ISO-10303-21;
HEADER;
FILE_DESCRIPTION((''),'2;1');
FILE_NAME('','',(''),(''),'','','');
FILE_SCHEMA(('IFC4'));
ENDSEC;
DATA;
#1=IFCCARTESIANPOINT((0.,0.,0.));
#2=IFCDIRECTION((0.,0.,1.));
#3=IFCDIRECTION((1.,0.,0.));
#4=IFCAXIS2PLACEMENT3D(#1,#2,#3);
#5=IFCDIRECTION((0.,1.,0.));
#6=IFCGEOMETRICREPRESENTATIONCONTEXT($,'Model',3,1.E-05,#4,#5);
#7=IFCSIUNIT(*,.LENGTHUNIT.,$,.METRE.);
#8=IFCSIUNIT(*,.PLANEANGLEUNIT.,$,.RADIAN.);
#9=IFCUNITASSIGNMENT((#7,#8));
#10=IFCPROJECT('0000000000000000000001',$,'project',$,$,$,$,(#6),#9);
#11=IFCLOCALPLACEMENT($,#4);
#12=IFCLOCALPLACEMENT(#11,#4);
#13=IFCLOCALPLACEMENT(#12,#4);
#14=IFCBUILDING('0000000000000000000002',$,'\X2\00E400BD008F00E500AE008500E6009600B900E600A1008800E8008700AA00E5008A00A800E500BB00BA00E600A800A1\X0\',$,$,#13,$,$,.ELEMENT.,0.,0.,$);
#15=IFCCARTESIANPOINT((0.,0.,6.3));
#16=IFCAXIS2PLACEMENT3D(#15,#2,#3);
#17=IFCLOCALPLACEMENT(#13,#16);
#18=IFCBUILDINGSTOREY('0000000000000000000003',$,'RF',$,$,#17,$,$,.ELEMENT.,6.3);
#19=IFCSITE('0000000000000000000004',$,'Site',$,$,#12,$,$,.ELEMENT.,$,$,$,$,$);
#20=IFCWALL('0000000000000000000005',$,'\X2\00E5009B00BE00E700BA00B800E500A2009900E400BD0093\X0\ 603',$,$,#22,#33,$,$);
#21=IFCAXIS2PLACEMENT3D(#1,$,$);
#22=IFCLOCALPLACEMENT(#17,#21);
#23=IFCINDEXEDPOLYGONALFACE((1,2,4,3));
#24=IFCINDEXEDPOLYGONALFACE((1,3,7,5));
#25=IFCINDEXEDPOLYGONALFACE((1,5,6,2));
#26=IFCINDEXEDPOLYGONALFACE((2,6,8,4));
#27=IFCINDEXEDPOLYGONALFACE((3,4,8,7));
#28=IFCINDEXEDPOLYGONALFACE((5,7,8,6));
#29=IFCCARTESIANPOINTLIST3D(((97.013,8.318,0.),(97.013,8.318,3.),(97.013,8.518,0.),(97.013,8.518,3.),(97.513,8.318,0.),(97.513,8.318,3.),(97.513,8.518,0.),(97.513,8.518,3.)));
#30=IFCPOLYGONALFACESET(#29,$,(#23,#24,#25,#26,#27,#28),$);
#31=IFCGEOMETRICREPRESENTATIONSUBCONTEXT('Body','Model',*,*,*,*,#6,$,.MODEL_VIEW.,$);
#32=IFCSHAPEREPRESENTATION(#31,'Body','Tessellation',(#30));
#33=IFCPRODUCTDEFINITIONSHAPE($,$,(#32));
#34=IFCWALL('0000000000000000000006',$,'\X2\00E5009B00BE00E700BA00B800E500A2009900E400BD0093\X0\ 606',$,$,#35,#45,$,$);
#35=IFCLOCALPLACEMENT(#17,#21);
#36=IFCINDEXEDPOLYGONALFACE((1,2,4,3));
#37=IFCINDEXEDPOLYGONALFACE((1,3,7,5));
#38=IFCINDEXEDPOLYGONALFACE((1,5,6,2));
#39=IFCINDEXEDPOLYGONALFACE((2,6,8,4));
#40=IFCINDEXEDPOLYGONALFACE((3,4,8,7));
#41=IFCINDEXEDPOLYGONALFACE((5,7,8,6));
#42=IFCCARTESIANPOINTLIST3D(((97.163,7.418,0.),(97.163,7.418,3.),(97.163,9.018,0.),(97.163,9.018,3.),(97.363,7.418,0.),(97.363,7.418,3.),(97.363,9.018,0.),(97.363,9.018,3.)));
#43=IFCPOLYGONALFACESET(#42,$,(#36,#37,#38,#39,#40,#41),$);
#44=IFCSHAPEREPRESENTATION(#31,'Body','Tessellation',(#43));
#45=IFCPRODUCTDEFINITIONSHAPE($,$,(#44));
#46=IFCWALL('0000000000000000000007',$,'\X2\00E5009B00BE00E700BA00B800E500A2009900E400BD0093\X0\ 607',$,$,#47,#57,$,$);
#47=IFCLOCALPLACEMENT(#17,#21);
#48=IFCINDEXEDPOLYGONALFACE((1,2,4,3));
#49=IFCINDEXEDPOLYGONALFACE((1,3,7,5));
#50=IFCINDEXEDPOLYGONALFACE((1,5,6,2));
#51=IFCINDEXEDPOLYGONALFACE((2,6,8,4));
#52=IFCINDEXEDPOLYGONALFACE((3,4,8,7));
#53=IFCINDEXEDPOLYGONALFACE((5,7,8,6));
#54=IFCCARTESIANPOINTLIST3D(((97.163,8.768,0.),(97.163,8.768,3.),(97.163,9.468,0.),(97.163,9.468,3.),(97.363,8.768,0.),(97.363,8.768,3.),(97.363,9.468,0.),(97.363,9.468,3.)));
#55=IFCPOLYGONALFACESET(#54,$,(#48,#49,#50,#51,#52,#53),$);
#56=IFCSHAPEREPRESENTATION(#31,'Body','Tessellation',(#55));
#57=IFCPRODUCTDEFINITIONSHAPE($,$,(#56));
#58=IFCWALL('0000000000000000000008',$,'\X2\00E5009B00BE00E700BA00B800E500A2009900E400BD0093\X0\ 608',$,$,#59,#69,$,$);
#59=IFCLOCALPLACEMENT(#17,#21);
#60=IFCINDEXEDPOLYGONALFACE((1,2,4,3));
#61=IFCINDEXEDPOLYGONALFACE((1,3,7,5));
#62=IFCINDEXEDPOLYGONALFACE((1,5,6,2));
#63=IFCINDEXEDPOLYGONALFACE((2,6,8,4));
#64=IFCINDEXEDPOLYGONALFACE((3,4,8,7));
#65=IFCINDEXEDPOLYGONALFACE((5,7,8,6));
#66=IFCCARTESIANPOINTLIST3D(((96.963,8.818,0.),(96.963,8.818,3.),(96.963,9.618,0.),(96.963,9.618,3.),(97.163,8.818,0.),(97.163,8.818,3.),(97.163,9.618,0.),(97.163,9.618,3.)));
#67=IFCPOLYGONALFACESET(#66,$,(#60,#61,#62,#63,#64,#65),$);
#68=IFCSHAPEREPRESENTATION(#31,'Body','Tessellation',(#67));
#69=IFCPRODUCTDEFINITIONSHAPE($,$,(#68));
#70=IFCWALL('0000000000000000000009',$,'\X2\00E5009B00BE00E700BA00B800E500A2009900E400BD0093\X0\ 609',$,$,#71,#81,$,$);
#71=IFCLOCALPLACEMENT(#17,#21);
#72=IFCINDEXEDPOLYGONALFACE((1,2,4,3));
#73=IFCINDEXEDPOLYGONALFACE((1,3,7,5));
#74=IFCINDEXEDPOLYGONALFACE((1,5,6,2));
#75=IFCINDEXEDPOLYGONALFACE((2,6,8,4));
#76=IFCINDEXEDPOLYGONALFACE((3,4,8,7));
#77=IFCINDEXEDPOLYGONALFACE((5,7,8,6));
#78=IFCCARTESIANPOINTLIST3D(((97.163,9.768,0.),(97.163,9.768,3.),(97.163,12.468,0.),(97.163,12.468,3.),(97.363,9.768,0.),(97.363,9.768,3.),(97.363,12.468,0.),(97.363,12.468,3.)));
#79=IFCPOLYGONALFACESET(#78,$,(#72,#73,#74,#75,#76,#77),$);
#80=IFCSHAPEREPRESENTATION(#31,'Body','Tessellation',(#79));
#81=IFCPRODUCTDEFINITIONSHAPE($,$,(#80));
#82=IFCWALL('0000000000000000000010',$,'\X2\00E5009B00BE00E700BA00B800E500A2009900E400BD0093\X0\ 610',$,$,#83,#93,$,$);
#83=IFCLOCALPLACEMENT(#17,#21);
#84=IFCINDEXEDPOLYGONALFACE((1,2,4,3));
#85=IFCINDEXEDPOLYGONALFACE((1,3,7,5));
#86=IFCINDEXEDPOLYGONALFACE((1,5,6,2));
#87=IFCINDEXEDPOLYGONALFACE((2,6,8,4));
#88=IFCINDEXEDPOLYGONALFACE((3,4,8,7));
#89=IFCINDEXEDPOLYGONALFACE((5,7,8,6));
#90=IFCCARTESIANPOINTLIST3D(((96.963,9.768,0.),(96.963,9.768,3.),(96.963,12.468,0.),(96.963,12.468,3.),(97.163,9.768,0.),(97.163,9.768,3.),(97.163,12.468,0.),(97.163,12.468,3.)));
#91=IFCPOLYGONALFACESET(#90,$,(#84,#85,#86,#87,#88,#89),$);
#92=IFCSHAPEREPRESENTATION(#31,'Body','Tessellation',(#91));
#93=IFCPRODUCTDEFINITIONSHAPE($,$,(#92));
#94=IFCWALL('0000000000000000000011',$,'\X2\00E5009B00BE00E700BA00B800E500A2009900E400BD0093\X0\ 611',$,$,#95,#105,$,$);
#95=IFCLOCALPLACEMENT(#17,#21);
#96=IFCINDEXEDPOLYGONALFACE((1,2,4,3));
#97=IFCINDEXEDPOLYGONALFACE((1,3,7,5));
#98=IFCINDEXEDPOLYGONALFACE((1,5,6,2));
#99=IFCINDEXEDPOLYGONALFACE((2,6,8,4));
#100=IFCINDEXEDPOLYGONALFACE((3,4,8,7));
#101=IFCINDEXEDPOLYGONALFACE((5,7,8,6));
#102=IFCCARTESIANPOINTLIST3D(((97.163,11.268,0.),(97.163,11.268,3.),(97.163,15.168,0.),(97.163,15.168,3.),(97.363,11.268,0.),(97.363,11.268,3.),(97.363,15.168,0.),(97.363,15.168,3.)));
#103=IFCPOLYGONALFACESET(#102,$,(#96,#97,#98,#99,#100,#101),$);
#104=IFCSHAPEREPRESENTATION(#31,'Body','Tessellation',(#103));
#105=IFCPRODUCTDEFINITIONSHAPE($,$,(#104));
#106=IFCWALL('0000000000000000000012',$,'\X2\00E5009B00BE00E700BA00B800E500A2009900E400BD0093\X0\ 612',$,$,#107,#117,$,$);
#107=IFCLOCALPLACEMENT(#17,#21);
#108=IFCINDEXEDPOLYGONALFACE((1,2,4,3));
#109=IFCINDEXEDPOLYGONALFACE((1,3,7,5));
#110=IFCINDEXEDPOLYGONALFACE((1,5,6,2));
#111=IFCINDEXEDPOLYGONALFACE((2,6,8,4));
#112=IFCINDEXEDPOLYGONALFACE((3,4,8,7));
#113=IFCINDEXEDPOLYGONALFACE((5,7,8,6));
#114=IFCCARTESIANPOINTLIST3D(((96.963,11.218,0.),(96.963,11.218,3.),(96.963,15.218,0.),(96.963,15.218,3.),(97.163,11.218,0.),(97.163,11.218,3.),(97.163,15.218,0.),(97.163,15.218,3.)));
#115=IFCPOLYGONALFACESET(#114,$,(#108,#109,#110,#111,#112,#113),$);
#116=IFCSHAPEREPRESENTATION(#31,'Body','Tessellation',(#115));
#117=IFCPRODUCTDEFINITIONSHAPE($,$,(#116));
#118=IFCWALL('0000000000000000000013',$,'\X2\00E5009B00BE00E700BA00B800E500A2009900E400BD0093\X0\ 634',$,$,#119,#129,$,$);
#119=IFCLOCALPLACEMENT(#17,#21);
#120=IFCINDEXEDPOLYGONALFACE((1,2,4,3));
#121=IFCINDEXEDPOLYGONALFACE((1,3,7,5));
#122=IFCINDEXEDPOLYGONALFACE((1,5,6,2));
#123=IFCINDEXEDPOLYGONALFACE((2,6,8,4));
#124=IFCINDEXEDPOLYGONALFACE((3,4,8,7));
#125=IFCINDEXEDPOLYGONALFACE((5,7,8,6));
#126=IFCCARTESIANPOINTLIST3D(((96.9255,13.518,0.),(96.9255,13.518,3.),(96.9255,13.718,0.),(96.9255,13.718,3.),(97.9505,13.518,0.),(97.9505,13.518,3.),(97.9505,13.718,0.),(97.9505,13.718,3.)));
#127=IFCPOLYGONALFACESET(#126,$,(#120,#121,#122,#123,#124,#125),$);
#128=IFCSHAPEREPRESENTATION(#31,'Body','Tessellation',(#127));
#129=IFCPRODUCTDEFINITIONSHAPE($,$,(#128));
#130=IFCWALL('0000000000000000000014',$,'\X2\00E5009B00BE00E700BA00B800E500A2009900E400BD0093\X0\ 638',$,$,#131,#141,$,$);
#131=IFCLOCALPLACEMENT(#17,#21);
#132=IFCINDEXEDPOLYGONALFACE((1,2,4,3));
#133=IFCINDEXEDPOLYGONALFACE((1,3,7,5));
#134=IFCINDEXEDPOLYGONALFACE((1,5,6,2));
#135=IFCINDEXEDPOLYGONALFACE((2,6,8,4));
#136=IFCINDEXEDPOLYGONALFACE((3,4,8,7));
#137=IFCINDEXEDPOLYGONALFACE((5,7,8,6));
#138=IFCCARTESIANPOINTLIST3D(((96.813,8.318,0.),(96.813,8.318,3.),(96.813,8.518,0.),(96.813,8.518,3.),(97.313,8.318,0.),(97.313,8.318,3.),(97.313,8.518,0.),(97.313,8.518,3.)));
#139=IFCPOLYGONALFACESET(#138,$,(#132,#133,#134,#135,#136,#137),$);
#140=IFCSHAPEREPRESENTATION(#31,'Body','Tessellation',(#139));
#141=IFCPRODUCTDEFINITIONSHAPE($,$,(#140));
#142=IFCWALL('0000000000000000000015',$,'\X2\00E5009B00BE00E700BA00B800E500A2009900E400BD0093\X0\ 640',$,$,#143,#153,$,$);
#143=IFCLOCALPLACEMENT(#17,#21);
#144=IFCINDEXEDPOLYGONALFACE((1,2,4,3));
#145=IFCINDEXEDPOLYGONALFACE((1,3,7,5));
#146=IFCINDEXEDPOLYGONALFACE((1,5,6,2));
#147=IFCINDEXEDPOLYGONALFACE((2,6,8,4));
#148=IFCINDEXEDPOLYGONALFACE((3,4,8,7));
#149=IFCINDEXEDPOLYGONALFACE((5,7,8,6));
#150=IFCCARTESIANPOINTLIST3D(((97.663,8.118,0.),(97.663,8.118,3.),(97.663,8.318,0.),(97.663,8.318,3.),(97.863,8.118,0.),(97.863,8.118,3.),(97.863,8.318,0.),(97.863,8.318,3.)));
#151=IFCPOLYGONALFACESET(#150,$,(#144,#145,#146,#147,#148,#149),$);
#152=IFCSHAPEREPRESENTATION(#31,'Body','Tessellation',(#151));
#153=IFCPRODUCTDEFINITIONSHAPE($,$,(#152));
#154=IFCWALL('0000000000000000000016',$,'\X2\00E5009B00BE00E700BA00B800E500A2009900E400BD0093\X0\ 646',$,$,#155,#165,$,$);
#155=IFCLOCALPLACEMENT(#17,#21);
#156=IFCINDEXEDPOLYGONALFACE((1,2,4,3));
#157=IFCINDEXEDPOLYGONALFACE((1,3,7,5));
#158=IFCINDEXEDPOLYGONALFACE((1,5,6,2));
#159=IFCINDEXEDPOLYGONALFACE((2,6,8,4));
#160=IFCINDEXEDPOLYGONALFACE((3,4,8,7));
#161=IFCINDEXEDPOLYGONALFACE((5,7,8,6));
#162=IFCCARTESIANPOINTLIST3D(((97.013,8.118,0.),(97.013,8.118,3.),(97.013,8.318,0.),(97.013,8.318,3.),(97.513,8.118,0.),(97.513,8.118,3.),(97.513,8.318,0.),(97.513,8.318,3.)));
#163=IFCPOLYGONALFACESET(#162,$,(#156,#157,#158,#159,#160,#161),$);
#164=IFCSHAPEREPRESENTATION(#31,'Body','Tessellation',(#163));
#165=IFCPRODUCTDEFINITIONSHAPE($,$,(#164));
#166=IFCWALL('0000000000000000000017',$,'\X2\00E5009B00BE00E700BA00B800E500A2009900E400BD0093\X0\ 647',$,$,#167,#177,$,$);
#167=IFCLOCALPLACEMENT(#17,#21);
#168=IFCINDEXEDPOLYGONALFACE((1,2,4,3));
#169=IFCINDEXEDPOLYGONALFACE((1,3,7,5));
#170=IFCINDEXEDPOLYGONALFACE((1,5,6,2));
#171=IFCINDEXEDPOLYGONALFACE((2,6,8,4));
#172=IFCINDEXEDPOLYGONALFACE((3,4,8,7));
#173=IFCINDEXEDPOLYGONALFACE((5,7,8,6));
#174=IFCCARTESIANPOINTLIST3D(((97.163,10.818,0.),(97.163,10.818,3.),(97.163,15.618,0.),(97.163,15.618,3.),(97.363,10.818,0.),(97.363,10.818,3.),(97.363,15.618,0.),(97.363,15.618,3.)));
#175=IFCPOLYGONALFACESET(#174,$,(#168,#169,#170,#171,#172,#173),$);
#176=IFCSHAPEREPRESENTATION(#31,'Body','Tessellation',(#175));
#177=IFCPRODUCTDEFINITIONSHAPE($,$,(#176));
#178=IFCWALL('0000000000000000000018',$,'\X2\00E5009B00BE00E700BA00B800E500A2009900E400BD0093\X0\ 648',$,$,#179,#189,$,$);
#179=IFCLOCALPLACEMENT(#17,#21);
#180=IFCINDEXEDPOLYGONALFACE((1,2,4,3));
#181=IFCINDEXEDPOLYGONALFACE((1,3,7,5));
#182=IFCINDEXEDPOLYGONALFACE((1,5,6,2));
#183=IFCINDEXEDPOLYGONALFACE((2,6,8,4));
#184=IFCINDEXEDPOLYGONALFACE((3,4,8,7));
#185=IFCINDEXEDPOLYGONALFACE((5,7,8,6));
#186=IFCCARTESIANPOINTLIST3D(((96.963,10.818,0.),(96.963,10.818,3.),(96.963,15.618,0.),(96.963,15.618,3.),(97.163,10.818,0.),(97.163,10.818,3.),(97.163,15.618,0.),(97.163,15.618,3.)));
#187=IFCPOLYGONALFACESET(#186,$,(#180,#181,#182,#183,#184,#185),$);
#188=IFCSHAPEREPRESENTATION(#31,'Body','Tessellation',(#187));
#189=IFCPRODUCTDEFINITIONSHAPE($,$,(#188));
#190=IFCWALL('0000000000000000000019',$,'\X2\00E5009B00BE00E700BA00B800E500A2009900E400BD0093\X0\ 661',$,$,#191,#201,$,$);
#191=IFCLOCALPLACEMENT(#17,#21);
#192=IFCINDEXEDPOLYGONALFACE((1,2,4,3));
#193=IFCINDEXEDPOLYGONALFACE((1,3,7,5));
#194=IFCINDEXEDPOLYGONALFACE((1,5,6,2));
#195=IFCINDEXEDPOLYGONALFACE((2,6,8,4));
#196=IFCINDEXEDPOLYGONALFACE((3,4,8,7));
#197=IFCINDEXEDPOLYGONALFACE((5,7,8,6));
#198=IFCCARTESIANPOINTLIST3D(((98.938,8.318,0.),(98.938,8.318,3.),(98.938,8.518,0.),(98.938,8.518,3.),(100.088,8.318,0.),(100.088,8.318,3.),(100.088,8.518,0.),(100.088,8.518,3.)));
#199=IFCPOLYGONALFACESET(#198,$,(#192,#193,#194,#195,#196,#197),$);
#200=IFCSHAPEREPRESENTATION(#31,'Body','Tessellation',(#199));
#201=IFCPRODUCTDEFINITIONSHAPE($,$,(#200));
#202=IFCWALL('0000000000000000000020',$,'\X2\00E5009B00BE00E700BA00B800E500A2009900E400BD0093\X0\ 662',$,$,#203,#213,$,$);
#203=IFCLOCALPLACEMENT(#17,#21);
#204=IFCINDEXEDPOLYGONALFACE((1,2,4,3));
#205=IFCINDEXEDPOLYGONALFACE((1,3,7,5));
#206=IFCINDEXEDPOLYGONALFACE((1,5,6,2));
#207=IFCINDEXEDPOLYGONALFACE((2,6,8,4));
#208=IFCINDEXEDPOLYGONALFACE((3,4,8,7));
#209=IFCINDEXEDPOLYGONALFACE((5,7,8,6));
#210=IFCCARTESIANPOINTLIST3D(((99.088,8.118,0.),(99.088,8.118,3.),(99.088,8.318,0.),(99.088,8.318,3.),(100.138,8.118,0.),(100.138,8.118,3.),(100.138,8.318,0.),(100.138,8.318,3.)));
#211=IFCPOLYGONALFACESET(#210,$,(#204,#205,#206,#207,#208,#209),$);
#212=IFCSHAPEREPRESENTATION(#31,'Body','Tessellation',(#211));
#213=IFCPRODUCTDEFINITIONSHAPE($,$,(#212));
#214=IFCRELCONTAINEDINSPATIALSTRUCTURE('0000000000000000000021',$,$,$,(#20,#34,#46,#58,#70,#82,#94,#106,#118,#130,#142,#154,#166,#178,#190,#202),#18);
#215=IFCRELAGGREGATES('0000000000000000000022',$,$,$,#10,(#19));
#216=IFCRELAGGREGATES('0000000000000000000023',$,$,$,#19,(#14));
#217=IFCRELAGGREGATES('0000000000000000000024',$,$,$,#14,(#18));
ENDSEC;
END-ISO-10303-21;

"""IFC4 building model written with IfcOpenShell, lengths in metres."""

from ifc_helpers import new_model, si_unit, direction, frame, frame_2d, origin_with_axes, place, context, subcontext, project, spatial, rectangle, extrude, element, save


model = new_model("IFC4")

# Units and contexts
model_context = context("Model", 3, precision=1e-05, world=origin_with_axes(), true_north=direction((0.0, 1.0, 0.0)))
body_context = subcontext(model_context, "Body", "Model", "MODEL_VIEW")
ifc_project = project(units=[si_unit("LENGTHUNIT", "METRE"), si_unit("PLANEANGLEUNIT", "RADIAN")], contexts=[model_context])

# Site, building, storey
placement = place(None, origin_with_axes())
site_placement = place(placement, origin_with_axes())
site = spatial("IfcSite", under=ifc_project, at=site_placement, Name="Site", CompositionType="ELEMENT")
building_placement = place(site_placement, origin_with_axes())
building = spatial("IfcBuilding", under=site, at=building_placement, Name="ä½\u008få®\u0085æ\u0096¹æ¡\u0088è\u0087ªå\u008a¨å»ºæ¨¡", CompositionType="ELEMENT", ElevationOfRefHeight=0.0, ElevationOfTerrain=0.0)
storey_placement = place(building_placement, frame((0.0, 0.0, 6.3), z_axis=(0.0, 0.0, 1.0), x_axis=(1.0, 0.0, 0.0)))
storey = spatial("IfcBuildingStorey", under=building, at=storey_placement, Name="RF", CompositionType="ELEMENT", Elevation=6.3)

# Walls
wall_1_placement = place(storey_placement, frame((97.263, 8.418, 0.0), z_axis=(0.0, 0.0, 1.0), x_axis=(1.0, 0.0, 0.0)))
element("IfcWall", 1, at=wall_1_placement, inside=storey, Name="å\u009b¾çº¸å¢\u0099ä½\u0093 603", context=body_context, shape_type="SweptSolid", body=[
    extrude(rectangle(XDim=0.5, YDim=0.2, at=frame_2d((0.0, 0.0), x_axis=(1.0, 0.0, 0.0))), frame((0.0, 0.0, 0.0), z_axis=(0.0, 0.0, 1.0)), (0.0, 0.0, 1.0), 3.0),
])
wall_2_placement = place(storey_placement, frame((97.263, 8.218, 0.0), z_axis=(0.0, 0.0, 1.0), x_axis=(0.0, -1.0, 0.0)))
element("IfcWall", 2, at=wall_2_placement, inside=storey, Name="å\u009b¾çº¸å¢\u0099ä½\u0093 606", context=body_context, shape_type="SweptSolid", body=[
    extrude(rectangle(XDim=1.6, YDim=0.2, at=frame_2d((0.0, 0.0), x_axis=(1.0, 0.0, 0.0))), frame((0.0, 0.0, 0.0), z_axis=(0.0, 0.0, 1.0)), (0.0, 0.0, 1.0), 3.0),
])
wall_3_placement = place(storey_placement, frame((97.263, 9.118, 0.0), z_axis=(0.0, 0.0, 1.0), x_axis=(0.0, -1.0, 0.0)))
element("IfcWall", 3, at=wall_3_placement, inside=storey, Name="å\u009b¾çº¸å¢\u0099ä½\u0093 607", context=body_context, shape_type="SweptSolid", body=[
    extrude(rectangle(XDim=0.7, YDim=0.2, at=frame_2d((0.0, 0.0), x_axis=(1.0, 0.0, 0.0))), frame((0.0, 0.0, 0.0), z_axis=(0.0, 0.0, 1.0)), (0.0, 0.0, 1.0), 3.0),
])
wall_4_placement = place(storey_placement, frame((97.063, 9.218, 0.0), z_axis=(0.0, 0.0, 1.0), x_axis=(0.0, -1.0, 0.0)))
element("IfcWall", 4, at=wall_4_placement, inside=storey, Name="å\u009b¾çº¸å¢\u0099ä½\u0093 608", context=body_context, shape_type="SweptSolid", body=[
    extrude(rectangle(XDim=0.8, YDim=0.2, at=frame_2d((0.0, 0.0), x_axis=(1.0, 0.0, 0.0))), frame((0.0, 0.0, 0.0), z_axis=(0.0, 0.0, 1.0)), (0.0, 0.0, 1.0), 3.0),
])
for number, where, z_axis, x_axis, name in (
    (5, (97.263, 11.118, 0.0), (0.0, 0.0, 1.0), (0.0, -1.0, 0.0), "å\u009b¾çº¸å¢\u0099ä½\u0093 609"),
    (6, (97.063, 11.118, 0.0), (0.0, 0.0, 1.0), (0.0, -1.0, 0.0), "å\u009b¾çº¸å¢\u0099ä½\u0093 610"),
):
    element("IfcWall", number, at=place(storey_placement, frame(where, z_axis=z_axis, x_axis=x_axis)), inside=storey, Name=name, context=body_context, shape_type="SweptSolid", body=[
        extrude(rectangle(XDim=2.7, YDim=0.2, at=frame_2d((0.0, 0.0), x_axis=(1.0, 0.0, 0.0))), frame((0.0, 0.0, 0.0), z_axis=(0.0, 0.0, 1.0)), (0.0, 0.0, 1.0), 3.0),
    ])
wall_5_placement = place(storey_placement, frame((97.263, 13.218, 0.0), z_axis=(0.0, 0.0, 1.0), x_axis=(0.0, -1.0, 0.0)))
element("IfcWall", 7, at=wall_5_placement, inside=storey, Name="å\u009b¾çº¸å¢\u0099ä½\u0093 611", context=body_context, shape_type="SweptSolid", body=[
    extrude(rectangle(XDim=3.9, YDim=0.2, at=frame_2d((0.0, 0.0), x_axis=(1.0, 0.0, 0.0))), frame((0.0, 0.0, 0.0), z_axis=(0.0, 0.0, 1.0)), (0.0, 0.0, 1.0), 3.0),
])
wall_6_placement = place(storey_placement, frame((97.063, 13.218, 0.0), z_axis=(0.0, 0.0, 1.0), x_axis=(0.0, -1.0, 0.0)))
element("IfcWall", 8, at=wall_6_placement, inside=storey, Name="å\u009b¾çº¸å¢\u0099ä½\u0093 612", context=body_context, shape_type="SweptSolid", body=[
    extrude(rectangle(XDim=4.0, YDim=0.2, at=frame_2d((0.0, 0.0), x_axis=(1.0, 0.0, 0.0))), frame((0.0, 0.0, 0.0), z_axis=(0.0, 0.0, 1.0)), (0.0, 0.0, 1.0), 3.0),
])
wall_7_placement = place(storey_placement, frame((97.438, 13.618, 0.0), z_axis=(0.0, 0.0, 1.0), x_axis=(1.0, 0.0, 0.0)))
element("IfcWall", 9, at=wall_7_placement, inside=storey, Name="å\u009b¾çº¸å¢\u0099ä½\u0093 634", context=body_context, shape_type="SweptSolid", body=[
    extrude(rectangle(XDim=1.025, YDim=0.2, at=frame_2d((0.0, 0.0), x_axis=(1.0, 0.0, 0.0))), frame((0.0, 0.0, 0.0), z_axis=(0.0, 0.0, 1.0)), (0.0, 0.0, 1.0), 3.0),
])
wall_8_placement = place(storey_placement, frame((97.063, 8.418, 0.0), z_axis=(0.0, 0.0, 1.0), x_axis=(-1.0, 0.0, 0.0)))
element("IfcWall", 10, at=wall_8_placement, inside=storey, Name="å\u009b¾çº¸å¢\u0099ä½\u0093 638", context=body_context, shape_type="SweptSolid", body=[
    extrude(rectangle(XDim=0.5, YDim=0.2, at=frame_2d((0.0, 0.0), x_axis=(1.0, 0.0, 0.0))), frame((0.0, 0.0, 0.0), z_axis=(0.0, 0.0, 1.0)), (0.0, 0.0, 1.0), 3.0),
])
wall_9_placement = place(storey_placement, frame((97.763, 8.218, 0.0), z_axis=(0.0, 0.0, 1.0), x_axis=(0.0, 1.0, 0.0)))
element("IfcWall", 11, at=wall_9_placement, inside=storey, Name="å\u009b¾çº¸å¢\u0099ä½\u0093 640", context=body_context, shape_type="SweptSolid", body=[
    extrude(rectangle(XDim=0.2, YDim=0.2, at=frame_2d((0.0, 0.0), x_axis=(1.0, 0.0, 0.0))), frame((0.0, 0.0, 0.0), z_axis=(0.0, 0.0, 1.0)), (0.0, 0.0, 1.0), 3.0),
])
for number, where, z_axis, x_axis, name in (
    (12, (97.263, 8.218, 0.0), (0.0, 0.0, 1.0), (1.0, 0.0, 0.0), "å\u009b¾çº¸å¢\u0099ä½\u0093 646"),
):
    element("IfcWall", number, at=place(storey_placement, frame(where, z_axis=z_axis, x_axis=x_axis)), inside=storey, Name=name, context=body_context, shape_type="SweptSolid", body=[
        extrude(rectangle(XDim=0.5, YDim=0.2, at=frame_2d((0.0, 0.0), x_axis=(1.0, 0.0, 0.0))), frame((0.0, 0.0, 0.0), z_axis=(0.0, 0.0, 1.0)), (0.0, 0.0, 1.0), 3.0),
    ])
for number, where, z_axis, x_axis, name in (
    (13, (97.263, 13.218, 0.0), (0.0, 0.0, 1.0), (0.0, -1.0, 0.0), "å\u009b¾çº¸å¢\u0099ä½\u0093 647"),
    (14, (97.063, 13.218, 0.0), (0.0, 0.0, 1.0), (0.0, -1.0, 0.0), "å\u009b¾çº¸å¢\u0099ä½\u0093 648"),
):
    element("IfcWall", number, at=place(storey_placement, frame(where, z_axis=z_axis, x_axis=x_axis)), inside=storey, Name=name, context=body_context, shape_type="SweptSolid", body=[
        extrude(rectangle(XDim=4.8, YDim=0.2, at=frame_2d((0.0, 0.0), x_axis=(1.0, 0.0, 0.0))), frame((0.0, 0.0, 0.0), z_axis=(0.0, 0.0, 1.0)), (0.0, 0.0, 1.0), 3.0),
    ])
wall_10_placement = place(storey_placement, frame((99.513, 8.418, 0.0), z_axis=(0.0, 0.0, 1.0), x_axis=(1.0, 0.0, 0.0)))
element("IfcWall", 15, at=wall_10_placement, inside=storey, Name="å\u009b¾çº¸å¢\u0099ä½\u0093 661", context=body_context, shape_type="SweptSolid", body=[
    extrude(rectangle(XDim=1.15, YDim=0.2, at=frame_2d((0.0, 0.0), x_axis=(1.0, 0.0, 0.0))), frame((0.0, 0.0, 0.0), z_axis=(0.0, 0.0, 1.0)), (0.0, 0.0, 1.0), 3.0),
])
wall_11_placement = place(storey_placement, frame((99.613, 8.218, 0.0), z_axis=(0.0, 0.0, 1.0), x_axis=(1.0, 0.0, 0.0)))
element("IfcWall", 16, at=wall_11_placement, inside=storey, Name="å\u009b¾çº¸å¢\u0099ä½\u0093 662", context=body_context, shape_type="SweptSolid", body=[
    extrude(rectangle(XDim=1.05, YDim=0.2, at=frame_2d((0.0, 0.0), x_axis=(1.0, 0.0, 0.0))), frame((0.0, 0.0, 0.0), z_axis=(0.0, 0.0, 1.0)), (0.0, 0.0, 1.0), 3.0),
])

save(model, "model.ifc")
